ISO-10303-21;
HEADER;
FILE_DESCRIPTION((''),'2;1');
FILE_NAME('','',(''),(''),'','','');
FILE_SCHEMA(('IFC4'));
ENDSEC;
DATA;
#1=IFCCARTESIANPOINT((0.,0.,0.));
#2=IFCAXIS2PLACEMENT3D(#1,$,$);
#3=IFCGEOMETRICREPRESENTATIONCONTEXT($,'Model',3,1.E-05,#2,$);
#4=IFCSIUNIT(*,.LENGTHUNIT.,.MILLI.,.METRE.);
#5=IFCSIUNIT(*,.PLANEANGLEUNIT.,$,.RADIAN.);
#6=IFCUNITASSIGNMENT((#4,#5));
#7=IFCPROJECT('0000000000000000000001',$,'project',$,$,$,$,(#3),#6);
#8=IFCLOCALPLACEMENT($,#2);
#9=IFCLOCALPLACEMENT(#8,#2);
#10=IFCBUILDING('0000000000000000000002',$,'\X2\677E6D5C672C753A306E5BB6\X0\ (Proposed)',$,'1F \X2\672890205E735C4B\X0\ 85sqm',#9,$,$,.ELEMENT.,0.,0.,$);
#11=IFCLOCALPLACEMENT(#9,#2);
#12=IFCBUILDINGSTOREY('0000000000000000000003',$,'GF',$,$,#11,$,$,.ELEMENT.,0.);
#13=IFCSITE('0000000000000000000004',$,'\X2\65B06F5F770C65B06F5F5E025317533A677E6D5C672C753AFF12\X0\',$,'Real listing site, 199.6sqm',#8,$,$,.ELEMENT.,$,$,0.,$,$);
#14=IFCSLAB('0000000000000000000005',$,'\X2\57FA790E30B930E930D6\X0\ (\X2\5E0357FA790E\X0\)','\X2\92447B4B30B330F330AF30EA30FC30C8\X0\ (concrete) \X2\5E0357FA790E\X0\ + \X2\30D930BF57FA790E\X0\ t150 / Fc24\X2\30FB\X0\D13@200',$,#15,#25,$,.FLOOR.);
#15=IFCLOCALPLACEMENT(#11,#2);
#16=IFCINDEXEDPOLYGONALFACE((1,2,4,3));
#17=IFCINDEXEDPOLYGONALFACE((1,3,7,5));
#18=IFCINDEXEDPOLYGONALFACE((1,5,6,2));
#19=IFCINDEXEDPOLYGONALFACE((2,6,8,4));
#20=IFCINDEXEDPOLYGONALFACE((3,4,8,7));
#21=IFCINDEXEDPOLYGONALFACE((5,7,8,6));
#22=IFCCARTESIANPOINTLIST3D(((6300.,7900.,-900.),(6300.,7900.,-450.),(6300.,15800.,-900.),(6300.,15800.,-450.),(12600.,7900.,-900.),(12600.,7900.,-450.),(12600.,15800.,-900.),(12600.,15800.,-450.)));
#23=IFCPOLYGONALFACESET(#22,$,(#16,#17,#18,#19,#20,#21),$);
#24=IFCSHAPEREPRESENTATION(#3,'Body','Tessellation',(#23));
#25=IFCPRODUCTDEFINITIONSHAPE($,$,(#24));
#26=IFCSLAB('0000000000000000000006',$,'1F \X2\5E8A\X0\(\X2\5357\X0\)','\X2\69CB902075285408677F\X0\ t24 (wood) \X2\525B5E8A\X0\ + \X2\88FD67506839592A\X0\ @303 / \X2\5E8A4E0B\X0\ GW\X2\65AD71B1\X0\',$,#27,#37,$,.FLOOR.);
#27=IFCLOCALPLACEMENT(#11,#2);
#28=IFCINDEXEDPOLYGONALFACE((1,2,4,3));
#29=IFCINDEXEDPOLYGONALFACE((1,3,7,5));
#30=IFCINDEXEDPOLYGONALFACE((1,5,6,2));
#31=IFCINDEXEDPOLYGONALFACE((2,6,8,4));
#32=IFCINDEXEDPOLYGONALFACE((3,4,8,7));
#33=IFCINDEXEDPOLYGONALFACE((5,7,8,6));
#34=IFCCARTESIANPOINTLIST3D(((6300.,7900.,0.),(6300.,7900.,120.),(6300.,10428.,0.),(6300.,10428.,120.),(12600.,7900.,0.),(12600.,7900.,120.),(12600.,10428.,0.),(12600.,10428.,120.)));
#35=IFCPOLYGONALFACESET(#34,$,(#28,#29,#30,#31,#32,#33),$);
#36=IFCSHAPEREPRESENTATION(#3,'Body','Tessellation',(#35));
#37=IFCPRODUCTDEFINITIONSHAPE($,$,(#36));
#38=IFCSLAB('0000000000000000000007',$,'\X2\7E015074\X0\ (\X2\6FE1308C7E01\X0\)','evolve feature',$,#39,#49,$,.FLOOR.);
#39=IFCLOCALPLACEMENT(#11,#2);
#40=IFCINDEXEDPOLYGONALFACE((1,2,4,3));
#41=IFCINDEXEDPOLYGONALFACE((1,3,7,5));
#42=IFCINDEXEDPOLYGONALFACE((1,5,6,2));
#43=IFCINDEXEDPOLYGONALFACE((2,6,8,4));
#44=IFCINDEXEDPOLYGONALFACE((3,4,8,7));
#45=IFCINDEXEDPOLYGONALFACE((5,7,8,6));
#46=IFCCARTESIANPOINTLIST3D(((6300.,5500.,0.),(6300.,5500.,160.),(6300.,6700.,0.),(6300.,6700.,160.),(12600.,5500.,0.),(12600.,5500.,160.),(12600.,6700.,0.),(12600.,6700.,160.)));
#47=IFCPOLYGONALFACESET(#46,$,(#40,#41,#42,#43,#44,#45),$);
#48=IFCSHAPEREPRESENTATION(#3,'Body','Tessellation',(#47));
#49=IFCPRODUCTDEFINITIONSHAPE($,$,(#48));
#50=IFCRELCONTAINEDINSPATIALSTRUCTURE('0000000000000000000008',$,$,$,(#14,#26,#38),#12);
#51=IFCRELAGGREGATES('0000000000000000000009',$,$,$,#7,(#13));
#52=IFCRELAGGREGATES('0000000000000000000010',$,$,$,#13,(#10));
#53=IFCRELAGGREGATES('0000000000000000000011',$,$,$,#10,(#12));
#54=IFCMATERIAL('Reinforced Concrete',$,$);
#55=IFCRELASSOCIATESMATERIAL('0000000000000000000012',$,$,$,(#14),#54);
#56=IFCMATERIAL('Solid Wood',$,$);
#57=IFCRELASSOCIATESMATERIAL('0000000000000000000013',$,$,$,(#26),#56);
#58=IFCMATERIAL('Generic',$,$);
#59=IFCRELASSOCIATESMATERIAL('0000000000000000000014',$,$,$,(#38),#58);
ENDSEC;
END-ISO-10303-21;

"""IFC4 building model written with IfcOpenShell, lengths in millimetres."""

from ifc_helpers import new_model, si_unit, frame, frame_2d, origin, place, context, project, spatial, rectangle, extrude, material, element, save


model = new_model("IFC4")

# Units and contexts
model_context = context("Model", 3, precision=1e-05, world=origin())
ifc_project = project(units=[si_unit("LENGTHUNIT", "METRE", prefix="MILLI"), si_unit("PLANEANGLEUNIT", "RADIAN")], contexts=[model_context])

# Site, building, storey
site_placement = place(None, origin())
site = spatial("IfcSite", under=ifc_project, at=site_placement, Name="新潟県新潟市北区松浜本町２", ObjectType="Real listing site, 199.6sqm", CompositionType="ELEMENT", RefElevation=0.0)
building_placement = place(site_placement, origin())
building = spatial("IfcBuilding", under=site, at=building_placement, Name="松浜本町の家 (Proposed)", ObjectType="1F 木造平屋 85sqm", CompositionType="ELEMENT", ElevationOfRefHeight=0.0, ElevationOfTerrain=0.0)
storey_placement = place(building_placement, origin())
storey = spatial("IfcBuildingStorey", under=building, at=storey_placement, Name="GF", CompositionType="ELEMENT", Elevation=0.0)

# Slabs
ifc_material_1 = material(Name="Reinforced Concrete")
slab_1_placement = place(storey_placement, frame((3150.0, 3950.0, -450.0)))
element("IfcSlab", 1, at=slab_1_placement, inside=storey, material=ifc_material_1, Name="基礎スラブ (布基礎)", Description="鉄筋コンクリート (concrete) 布基礎 + ベタ基礎 t150 / Fc24・D13@200", PredefinedType="FLOOR", context=model_context, shape_type="SweptSolid", body=[
    extrude(rectangle(XDim=6300.0, YDim=7900.0, at=frame_2d((3150.0, 3950.0))), frame((3150.0, 3950.0, -450.0)), (0.0, 0.0, 1.0), 450.0),
])
ifc_material_2 = material(Name="Solid Wood")
slab_2_placement = place(storey_placement, frame((3150.0, 3950.0, 0.0)))
element("IfcSlab", 2, at=slab_2_placement, inside=storey, material=ifc_material_2, Name="1F 床(南)", Description="構造用合板 t24 (wood) 剛床 + 製材根太 @303 / 床下 GW断熱", PredefinedType="FLOOR", context=model_context, shape_type="SweptSolid", body=[
    extrude(rectangle(XDim=6300.0, YDim=2528.0, at=frame_2d((3150.0, 1264.0))), frame((3150.0, 3950.0, 0.0)), (0.0, 0.0, 1.0), 120.0),
])
ifc_material_3 = material(Name="Generic")
slab_3_placement = place(storey_placement, frame((3150.0, 2750.0, 0.0)))
element("IfcSlab", 3, at=slab_3_placement, inside=storey, material=ifc_material_3, Name="縁側 (濡れ縁)", Description="evolve feature", PredefinedType="FLOOR", context=model_context, shape_type="SweptSolid", body=[
    extrude(rectangle(XDim=6300.0, YDim=1200.0, at=frame_2d((3150.0, 600.0))), frame((3150.0, 2750.0, 0.0)), (0.0, 0.0, 1.0), 160.0),
])

save(model, "model.ifc")
